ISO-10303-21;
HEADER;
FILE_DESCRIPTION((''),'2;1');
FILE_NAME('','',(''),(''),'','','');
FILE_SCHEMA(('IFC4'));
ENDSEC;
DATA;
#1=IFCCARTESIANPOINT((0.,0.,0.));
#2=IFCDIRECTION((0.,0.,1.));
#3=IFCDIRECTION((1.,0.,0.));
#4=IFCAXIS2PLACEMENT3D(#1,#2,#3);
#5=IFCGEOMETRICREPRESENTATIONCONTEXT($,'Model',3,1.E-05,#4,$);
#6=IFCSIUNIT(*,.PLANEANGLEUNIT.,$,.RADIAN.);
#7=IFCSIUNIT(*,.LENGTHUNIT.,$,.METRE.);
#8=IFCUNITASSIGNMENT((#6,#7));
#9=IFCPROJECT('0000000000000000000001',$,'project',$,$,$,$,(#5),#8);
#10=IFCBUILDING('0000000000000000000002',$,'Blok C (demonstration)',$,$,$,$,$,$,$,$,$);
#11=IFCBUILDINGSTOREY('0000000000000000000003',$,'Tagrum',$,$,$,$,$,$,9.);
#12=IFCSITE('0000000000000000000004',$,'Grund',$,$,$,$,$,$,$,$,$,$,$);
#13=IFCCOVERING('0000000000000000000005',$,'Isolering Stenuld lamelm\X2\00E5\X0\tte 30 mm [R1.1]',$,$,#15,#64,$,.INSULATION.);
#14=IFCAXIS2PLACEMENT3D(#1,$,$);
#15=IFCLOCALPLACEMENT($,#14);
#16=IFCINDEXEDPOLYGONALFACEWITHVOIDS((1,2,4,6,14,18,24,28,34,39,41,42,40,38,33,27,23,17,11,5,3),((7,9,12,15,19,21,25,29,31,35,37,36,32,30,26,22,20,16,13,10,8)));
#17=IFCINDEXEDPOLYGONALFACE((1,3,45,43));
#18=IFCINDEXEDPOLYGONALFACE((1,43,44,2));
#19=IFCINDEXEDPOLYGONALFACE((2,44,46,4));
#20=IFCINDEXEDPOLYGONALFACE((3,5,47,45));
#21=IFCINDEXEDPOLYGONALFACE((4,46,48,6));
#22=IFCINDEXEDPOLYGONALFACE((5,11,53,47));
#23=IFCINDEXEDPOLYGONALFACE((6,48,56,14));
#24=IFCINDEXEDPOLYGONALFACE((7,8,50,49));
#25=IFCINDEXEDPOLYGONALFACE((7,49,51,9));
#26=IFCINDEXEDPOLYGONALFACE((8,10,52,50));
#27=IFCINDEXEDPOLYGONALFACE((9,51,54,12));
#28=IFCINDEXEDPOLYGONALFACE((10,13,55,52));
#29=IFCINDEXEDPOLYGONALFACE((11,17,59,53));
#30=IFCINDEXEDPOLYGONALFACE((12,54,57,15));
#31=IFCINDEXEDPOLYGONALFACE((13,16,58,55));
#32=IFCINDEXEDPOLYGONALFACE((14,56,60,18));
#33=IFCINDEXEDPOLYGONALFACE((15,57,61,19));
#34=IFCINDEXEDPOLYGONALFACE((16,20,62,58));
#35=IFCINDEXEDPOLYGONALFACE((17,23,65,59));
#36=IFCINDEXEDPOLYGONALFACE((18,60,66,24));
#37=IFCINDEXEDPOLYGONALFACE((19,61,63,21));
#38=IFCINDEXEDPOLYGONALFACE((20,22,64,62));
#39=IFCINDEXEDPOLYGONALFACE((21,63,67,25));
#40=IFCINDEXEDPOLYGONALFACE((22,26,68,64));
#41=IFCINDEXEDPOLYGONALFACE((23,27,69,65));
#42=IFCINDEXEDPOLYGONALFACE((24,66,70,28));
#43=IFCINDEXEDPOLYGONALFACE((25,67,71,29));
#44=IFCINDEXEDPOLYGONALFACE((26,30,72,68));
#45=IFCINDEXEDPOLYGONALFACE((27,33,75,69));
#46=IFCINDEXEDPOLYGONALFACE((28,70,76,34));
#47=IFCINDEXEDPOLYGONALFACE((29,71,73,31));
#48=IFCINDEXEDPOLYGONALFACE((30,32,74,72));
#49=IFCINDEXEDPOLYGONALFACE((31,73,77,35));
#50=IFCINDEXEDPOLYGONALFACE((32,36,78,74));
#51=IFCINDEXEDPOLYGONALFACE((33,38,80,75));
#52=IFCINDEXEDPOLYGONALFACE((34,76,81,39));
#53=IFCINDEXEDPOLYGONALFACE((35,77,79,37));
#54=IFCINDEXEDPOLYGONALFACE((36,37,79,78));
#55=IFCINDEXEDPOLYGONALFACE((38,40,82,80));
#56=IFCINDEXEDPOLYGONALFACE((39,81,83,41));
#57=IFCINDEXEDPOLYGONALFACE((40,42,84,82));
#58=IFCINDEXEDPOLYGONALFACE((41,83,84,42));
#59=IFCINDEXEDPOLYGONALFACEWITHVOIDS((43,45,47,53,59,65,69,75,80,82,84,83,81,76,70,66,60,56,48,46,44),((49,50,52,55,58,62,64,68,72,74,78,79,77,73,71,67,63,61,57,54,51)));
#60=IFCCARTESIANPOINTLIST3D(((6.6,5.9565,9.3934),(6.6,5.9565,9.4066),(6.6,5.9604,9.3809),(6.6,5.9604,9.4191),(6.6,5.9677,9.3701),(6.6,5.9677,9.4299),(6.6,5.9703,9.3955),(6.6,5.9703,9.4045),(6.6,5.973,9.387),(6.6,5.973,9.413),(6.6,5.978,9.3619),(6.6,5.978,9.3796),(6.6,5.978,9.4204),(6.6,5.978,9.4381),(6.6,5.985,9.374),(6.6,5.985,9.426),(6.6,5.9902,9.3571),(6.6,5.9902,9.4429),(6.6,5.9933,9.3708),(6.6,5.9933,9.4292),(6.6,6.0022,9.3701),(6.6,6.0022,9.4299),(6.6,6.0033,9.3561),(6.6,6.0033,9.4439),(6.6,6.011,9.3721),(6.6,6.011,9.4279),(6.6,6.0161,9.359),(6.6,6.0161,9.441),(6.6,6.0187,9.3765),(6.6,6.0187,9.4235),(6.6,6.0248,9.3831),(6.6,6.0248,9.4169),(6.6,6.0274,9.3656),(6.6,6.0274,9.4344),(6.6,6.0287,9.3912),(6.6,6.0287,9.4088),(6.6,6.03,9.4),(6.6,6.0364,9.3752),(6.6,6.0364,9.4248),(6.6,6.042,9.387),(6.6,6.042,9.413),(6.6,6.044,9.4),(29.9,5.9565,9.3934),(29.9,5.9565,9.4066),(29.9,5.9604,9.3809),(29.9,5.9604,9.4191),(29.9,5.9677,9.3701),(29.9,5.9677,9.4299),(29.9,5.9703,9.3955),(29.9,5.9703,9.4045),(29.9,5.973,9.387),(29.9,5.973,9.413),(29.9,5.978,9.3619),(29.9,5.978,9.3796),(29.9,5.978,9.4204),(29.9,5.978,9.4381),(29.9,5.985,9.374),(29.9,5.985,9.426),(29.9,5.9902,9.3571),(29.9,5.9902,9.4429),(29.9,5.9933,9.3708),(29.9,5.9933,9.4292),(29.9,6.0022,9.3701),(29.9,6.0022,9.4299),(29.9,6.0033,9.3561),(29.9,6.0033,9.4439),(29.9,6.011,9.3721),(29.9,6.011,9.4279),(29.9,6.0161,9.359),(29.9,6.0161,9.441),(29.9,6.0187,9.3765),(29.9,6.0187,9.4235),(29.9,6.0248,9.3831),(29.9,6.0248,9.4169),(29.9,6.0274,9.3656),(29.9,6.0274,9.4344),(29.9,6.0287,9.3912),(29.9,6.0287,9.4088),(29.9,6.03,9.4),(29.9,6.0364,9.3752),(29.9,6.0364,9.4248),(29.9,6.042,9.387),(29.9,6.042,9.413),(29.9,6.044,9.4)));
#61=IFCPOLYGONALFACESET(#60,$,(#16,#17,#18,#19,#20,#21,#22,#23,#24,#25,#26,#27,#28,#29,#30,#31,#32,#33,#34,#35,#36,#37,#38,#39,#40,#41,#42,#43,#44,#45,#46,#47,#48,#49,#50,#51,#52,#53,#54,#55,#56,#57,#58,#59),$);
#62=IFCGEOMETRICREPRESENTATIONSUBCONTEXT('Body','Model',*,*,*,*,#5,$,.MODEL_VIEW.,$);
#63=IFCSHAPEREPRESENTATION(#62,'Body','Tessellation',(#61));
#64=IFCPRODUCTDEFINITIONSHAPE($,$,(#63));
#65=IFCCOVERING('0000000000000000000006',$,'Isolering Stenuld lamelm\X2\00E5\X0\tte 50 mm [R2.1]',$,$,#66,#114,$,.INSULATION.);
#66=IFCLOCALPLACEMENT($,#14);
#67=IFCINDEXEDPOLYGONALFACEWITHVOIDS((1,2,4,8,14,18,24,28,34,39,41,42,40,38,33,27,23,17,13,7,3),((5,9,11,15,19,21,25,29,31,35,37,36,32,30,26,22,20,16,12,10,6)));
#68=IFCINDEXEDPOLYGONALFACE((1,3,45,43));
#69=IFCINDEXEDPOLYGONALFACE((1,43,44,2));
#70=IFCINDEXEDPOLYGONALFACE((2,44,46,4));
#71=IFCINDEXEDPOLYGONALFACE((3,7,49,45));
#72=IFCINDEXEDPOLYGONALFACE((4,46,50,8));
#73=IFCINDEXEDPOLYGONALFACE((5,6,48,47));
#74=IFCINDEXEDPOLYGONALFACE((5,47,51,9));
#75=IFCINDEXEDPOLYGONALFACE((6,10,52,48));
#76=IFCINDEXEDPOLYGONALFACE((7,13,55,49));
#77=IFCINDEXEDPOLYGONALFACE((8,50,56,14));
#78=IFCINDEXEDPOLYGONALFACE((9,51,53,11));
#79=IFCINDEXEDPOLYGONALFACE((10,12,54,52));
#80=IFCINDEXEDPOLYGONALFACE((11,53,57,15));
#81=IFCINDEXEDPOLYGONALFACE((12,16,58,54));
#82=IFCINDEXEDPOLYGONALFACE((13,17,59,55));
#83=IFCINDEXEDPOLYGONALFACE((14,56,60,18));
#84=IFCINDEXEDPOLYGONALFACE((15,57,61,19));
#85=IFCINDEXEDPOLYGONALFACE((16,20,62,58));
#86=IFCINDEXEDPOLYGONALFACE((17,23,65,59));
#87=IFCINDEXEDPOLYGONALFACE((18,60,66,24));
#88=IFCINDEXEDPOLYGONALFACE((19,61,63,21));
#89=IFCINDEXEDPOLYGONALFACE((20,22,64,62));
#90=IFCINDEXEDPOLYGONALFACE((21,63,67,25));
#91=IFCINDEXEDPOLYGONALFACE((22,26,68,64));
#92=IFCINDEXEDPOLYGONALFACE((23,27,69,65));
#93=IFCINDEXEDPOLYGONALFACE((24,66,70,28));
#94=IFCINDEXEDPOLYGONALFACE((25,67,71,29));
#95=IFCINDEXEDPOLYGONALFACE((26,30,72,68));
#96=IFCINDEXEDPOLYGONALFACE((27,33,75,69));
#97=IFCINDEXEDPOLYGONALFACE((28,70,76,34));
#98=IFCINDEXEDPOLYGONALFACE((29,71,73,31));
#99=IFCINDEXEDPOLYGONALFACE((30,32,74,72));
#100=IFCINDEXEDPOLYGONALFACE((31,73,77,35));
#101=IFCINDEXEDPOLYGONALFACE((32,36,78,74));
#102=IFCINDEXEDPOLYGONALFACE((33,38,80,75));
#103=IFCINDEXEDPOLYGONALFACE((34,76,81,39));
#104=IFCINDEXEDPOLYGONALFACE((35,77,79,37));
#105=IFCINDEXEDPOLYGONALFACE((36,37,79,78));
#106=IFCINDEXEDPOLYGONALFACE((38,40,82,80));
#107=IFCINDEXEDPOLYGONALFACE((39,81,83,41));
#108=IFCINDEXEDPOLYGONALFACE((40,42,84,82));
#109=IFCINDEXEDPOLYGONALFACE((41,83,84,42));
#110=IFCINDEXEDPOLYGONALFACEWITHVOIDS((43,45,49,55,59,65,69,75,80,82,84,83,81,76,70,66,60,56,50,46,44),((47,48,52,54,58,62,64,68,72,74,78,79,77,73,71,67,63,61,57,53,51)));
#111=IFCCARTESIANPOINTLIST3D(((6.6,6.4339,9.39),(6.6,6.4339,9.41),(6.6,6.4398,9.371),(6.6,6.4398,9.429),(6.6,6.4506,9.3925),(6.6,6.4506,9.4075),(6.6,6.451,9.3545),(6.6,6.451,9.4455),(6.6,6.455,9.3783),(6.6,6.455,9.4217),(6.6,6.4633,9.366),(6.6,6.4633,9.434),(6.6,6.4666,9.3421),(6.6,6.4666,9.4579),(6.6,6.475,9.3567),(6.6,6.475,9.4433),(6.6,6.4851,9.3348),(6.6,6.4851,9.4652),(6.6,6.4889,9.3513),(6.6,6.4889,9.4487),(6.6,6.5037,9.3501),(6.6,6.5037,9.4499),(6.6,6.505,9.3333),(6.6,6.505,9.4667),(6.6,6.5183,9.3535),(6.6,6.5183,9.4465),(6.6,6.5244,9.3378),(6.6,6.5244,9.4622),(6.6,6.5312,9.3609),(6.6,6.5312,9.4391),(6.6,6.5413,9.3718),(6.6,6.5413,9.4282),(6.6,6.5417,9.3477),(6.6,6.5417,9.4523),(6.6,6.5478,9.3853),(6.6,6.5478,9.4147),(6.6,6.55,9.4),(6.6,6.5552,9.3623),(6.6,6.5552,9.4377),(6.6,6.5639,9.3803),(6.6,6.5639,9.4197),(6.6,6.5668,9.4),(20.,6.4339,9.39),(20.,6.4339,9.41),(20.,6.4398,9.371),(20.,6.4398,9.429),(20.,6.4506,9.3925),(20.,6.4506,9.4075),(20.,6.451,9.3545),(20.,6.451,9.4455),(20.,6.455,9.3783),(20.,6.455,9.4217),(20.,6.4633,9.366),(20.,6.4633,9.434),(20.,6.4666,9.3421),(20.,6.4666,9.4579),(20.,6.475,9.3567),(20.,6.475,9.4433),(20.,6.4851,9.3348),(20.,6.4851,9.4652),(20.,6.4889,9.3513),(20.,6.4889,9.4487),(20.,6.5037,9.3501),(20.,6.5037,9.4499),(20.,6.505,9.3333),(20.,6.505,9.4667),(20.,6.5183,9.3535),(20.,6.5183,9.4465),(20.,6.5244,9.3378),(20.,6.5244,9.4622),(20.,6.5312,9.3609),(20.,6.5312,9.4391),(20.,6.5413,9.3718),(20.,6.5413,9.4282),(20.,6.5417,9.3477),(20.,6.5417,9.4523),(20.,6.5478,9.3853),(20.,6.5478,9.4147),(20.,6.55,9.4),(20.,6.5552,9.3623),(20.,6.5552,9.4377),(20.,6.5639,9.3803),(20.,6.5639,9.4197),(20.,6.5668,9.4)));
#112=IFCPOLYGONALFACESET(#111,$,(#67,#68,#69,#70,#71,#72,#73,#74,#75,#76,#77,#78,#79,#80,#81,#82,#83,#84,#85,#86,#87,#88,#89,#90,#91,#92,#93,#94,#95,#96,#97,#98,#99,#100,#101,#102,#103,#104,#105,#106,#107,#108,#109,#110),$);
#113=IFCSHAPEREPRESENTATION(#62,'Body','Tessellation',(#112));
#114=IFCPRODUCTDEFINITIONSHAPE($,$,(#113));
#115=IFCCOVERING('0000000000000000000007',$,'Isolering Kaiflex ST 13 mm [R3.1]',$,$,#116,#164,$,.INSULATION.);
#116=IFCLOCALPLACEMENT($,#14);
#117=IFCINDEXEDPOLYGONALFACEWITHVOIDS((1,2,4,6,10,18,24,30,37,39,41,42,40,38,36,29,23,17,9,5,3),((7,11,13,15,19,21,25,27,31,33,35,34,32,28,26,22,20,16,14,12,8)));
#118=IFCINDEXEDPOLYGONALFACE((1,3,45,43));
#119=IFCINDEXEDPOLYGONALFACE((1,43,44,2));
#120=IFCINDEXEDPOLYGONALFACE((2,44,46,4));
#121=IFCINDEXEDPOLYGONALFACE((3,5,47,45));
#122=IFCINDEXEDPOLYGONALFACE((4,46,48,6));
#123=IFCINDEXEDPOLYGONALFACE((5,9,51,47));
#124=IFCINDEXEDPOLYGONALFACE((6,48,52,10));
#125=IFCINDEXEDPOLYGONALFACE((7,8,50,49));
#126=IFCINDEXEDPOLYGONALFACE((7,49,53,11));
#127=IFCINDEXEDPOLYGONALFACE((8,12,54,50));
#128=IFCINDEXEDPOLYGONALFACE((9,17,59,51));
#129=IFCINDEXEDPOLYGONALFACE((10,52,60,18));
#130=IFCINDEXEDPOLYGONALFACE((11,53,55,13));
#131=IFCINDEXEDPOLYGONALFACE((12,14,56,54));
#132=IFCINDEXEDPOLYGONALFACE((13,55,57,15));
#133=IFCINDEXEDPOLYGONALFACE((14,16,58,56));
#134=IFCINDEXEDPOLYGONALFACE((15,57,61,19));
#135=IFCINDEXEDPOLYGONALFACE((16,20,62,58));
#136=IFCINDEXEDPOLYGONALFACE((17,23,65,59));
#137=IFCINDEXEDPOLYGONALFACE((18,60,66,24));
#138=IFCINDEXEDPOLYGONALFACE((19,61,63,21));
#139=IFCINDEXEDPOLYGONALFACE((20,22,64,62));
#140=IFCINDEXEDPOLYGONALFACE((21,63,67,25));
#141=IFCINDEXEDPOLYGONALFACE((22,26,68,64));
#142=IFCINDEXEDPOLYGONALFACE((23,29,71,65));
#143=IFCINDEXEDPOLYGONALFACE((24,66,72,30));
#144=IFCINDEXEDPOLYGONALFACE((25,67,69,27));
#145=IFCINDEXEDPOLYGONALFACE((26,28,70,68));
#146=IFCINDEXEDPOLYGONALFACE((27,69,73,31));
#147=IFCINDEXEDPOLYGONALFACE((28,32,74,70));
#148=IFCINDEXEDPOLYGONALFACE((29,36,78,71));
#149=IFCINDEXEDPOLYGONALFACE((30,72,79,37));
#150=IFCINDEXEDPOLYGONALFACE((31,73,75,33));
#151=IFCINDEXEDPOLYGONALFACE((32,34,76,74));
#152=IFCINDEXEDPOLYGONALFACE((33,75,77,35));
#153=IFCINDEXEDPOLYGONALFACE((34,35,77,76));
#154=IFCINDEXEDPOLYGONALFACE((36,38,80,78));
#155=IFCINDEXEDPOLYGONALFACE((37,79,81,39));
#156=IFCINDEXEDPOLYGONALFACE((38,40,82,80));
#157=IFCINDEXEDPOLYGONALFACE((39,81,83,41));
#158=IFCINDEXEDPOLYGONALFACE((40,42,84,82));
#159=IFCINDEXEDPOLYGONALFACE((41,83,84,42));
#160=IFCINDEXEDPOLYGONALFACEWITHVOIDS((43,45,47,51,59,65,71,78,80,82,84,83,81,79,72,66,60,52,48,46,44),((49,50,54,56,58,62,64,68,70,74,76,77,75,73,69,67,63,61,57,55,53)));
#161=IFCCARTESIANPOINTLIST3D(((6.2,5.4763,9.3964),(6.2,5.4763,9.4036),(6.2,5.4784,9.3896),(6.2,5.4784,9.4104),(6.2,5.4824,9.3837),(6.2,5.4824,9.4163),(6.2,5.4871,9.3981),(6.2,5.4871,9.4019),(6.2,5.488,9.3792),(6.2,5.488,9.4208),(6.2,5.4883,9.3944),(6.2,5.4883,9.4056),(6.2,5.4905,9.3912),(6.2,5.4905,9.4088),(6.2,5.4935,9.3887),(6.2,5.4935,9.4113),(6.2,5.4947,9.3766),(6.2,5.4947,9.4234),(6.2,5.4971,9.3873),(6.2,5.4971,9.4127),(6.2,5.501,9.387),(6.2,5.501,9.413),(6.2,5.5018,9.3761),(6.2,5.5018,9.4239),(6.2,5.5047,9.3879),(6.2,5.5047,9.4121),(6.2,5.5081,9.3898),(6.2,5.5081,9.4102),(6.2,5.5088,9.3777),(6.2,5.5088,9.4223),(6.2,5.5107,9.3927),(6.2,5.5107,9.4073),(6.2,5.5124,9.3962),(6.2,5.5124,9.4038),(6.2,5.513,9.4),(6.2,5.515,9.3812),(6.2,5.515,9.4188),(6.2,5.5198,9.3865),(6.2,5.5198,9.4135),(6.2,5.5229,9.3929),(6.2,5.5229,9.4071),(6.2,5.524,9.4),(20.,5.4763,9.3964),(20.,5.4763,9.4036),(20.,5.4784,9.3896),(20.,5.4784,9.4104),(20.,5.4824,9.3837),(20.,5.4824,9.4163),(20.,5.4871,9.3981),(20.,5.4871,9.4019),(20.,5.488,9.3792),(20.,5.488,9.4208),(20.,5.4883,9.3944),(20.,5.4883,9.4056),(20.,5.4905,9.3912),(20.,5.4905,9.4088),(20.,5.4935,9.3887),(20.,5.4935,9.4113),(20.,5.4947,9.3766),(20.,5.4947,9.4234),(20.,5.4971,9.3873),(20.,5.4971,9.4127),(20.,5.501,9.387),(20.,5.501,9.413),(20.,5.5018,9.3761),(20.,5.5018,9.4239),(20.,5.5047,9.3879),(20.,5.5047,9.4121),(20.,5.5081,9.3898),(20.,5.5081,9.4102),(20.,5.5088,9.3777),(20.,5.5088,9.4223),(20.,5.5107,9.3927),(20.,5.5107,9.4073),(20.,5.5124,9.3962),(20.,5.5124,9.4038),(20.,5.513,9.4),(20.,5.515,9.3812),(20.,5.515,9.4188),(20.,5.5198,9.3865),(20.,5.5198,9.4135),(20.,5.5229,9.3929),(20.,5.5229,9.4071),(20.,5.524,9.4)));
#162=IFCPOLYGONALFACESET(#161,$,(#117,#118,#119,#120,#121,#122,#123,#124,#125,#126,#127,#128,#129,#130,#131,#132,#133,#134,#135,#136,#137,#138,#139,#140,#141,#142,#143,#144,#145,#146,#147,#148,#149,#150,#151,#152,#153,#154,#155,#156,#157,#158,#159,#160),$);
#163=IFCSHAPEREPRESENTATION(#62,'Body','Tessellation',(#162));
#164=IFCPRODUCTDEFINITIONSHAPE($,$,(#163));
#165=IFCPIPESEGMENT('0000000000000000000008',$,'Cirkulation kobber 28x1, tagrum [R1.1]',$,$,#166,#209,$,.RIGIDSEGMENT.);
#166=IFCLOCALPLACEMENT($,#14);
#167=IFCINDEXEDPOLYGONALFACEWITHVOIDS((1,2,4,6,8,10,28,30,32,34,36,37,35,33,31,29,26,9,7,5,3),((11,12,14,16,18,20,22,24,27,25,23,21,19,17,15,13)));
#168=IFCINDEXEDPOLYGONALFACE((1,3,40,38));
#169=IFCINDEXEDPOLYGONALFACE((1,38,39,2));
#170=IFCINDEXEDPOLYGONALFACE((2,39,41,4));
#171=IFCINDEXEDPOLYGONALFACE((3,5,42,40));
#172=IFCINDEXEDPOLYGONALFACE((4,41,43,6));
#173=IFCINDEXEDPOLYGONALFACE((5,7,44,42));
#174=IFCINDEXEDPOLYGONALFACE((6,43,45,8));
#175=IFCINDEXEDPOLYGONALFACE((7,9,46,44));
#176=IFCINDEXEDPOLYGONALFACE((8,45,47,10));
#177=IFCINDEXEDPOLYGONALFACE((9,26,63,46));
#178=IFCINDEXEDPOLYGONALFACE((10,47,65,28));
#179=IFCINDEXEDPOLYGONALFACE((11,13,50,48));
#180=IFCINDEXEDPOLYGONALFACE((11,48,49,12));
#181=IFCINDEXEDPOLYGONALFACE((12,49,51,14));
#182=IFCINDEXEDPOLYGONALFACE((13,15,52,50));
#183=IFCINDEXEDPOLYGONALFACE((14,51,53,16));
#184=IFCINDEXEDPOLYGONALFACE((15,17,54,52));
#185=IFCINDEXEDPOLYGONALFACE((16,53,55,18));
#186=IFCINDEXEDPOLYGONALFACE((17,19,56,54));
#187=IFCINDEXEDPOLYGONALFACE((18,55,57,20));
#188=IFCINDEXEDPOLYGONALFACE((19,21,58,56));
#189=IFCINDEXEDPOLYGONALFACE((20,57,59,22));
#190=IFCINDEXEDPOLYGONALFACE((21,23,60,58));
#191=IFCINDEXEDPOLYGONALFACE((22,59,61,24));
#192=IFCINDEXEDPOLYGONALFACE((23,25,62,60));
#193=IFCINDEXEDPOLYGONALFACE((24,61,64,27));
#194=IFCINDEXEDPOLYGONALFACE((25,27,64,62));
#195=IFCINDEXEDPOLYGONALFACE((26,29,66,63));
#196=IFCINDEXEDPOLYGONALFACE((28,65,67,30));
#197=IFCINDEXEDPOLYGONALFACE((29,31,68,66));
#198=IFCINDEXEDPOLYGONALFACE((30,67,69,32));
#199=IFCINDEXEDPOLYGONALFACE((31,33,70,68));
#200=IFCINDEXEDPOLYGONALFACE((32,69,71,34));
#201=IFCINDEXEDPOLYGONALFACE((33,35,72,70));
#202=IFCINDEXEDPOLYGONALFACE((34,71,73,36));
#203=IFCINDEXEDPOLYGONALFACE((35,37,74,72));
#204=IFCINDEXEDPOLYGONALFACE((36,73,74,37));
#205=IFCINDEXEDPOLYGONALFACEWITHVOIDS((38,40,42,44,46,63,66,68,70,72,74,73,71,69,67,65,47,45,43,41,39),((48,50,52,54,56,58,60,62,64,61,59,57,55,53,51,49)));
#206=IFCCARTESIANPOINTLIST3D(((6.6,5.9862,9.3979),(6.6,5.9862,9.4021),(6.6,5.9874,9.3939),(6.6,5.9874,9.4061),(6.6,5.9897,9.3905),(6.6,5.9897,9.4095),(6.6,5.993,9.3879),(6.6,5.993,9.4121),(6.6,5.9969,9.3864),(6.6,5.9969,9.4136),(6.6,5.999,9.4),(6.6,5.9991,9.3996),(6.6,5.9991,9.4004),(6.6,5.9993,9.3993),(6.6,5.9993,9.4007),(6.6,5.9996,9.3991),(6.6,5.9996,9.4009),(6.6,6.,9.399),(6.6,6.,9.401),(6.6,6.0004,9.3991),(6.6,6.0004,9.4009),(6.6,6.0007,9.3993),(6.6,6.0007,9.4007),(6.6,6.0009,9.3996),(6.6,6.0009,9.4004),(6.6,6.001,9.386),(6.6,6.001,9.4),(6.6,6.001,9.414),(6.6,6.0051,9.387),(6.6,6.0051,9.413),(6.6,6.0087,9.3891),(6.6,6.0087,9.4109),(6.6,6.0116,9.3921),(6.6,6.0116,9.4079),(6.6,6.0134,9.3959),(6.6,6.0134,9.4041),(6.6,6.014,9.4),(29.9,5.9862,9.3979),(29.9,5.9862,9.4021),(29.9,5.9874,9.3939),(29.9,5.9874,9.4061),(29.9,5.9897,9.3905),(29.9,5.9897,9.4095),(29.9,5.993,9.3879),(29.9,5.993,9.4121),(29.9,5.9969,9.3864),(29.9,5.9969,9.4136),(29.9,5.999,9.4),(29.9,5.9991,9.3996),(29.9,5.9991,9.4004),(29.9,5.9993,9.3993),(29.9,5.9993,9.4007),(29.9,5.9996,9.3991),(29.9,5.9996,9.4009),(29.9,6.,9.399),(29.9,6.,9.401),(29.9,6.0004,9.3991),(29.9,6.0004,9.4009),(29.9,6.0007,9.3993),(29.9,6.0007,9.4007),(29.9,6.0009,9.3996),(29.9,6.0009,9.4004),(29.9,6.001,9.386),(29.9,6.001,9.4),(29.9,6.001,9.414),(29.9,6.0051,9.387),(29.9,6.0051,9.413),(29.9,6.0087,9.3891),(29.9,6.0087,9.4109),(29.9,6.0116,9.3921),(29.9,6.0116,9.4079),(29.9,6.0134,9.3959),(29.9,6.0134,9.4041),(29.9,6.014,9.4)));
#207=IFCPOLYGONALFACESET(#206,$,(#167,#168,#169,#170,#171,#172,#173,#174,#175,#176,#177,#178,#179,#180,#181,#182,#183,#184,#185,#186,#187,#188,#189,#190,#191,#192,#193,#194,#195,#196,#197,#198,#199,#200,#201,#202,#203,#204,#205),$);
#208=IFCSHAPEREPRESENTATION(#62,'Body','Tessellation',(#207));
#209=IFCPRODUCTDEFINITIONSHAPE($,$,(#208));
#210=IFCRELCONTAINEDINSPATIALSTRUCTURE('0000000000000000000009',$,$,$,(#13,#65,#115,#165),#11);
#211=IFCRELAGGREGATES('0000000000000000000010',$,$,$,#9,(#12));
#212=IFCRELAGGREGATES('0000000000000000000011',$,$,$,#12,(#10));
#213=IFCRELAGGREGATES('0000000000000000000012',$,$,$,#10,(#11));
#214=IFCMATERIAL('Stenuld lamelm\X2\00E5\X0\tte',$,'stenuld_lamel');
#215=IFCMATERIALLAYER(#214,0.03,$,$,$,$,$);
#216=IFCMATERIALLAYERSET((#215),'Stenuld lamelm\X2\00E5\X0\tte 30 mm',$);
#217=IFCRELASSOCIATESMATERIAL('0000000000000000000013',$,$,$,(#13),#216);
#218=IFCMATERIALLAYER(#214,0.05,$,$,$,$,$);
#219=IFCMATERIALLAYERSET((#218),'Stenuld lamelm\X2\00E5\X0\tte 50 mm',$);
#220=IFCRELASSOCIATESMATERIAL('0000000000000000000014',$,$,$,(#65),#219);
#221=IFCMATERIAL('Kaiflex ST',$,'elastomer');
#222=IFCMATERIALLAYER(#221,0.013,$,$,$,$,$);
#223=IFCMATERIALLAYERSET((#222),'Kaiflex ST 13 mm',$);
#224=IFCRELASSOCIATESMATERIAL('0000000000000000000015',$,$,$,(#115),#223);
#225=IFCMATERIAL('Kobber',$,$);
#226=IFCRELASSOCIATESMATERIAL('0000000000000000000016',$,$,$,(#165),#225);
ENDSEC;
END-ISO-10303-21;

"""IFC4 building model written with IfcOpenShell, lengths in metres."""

from ifc_helpers import new_model, si_unit, frame, origin_with_axes, place, context, subcontext, project, spatial, hollow_circle, extrude, material, layer, layer_set, element, save


model = new_model("IFC4")

# Units and contexts
model_context = context("Model", 3, precision=1e-05, world=origin_with_axes())
body_context = subcontext(model_context, "Body", "Model", "MODEL_VIEW")
ifc_project = project(units=[si_unit("PLANEANGLEUNIT", "RADIAN"), si_unit("LENGTHUNIT", "METRE")], contexts=[model_context])

# Site, building, storey
site = spatial("IfcSite", under=ifc_project, Name="Grund")
building = spatial("IfcBuilding", under=site, Name="Blok C (demonstration)")
storey = spatial("IfcBuildingStorey", under=building, Name="Tagrum", Elevation=9.0)

# Coverings
ifc_material_1 = material(Name="Stenuld lamelmåtte", Category="stenuld_lamel")
ifc_layer_1 = layer(ifc_material_1, 0.03)
ifc_layer_set_1 = layer_set([ifc_layer_1], Name="Stenuld lamelmåtte 30 mm")
covering_1_placement = place(None, origin_with_axes())
element("IfcCovering", 1, at=covering_1_placement, inside=storey, material=ifc_layer_set_1, Name="Isolering Stenuld lamelmåtte 30 mm [R1.1]", PredefinedType="INSULATION", context=body_context, shape_type="SweptSolid", body=[
    extrude(hollow_circle(Radius=0.044, WallThickness=0.014), frame((6.6, 6.0, 9.4), z_axis=(1.0, 0.0, 0.0), x_axis=(0.0, 1.0, 0.0)), (0.0, 0.0, 1.0), 23.3),
])
ifc_layer_2 = layer(ifc_material_1, 0.05)
ifc_layer_set_2 = layer_set([ifc_layer_2], Name="Stenuld lamelmåtte 50 mm")
covering_2_placement = place(None, origin_with_axes())
element("IfcCovering", 2, at=covering_2_placement, inside=storey, material=ifc_layer_set_2, Name="Isolering Stenuld lamelmåtte 50 mm [R2.1]", PredefinedType="INSULATION", context=body_context, shape_type="SweptSolid", body=[
    extrude(hollow_circle(Radius=0.0669, WallThickness=0.0169), frame((6.6, 6.5, 9.4), z_axis=(1.0, 0.0, 0.0), x_axis=(0.0, 1.0, 0.0)), (0.0, 0.0, 1.0), 13.4),
])
ifc_material_2 = material(Name="Kaiflex ST", Category="elastomer")
ifc_layer_3 = layer(ifc_material_2, 0.013)
ifc_layer_set_3 = layer_set([ifc_layer_3], Name="Kaiflex ST 13 mm")
covering_3_placement = place(None, origin_with_axes())
element("IfcCovering", 3, at=covering_3_placement, inside=storey, material=ifc_layer_set_3, Name="Isolering Kaiflex ST 13 mm [R3.1]", PredefinedType="INSULATION", context=body_context, shape_type="SweptSolid", body=[
    extrude(hollow_circle(Radius=0.024, WallThickness=0.011), frame((6.2, 5.5, 9.4), z_axis=(1.0, 0.0, 0.0), x_axis=(0.0, 1.0, 0.0)), (0.0, 0.0, 1.0), 13.8),
])

# Pipe segment
ifc_material_3 = material(Name="Kobber")
pipe_segment_1_placement = place(None, origin_with_axes())
element("IfcPipeSegment", 4, at=pipe_segment_1_placement, inside=storey, material=ifc_material_3, Name="Cirkulation kobber 28x1, tagrum [R1.1]", PredefinedType="RIGIDSEGMENT", context=body_context, shape_type="SweptSolid", body=[
    extrude(hollow_circle(Radius=0.014, WallThickness=0.013), frame((6.6, 6.0, 9.4), z_axis=(1.0, 0.0, 0.0), x_axis=(0.0, 1.0, 0.0)), (0.0, 0.0, 1.0), 23.3),
])

save(model, "model.ifc")
